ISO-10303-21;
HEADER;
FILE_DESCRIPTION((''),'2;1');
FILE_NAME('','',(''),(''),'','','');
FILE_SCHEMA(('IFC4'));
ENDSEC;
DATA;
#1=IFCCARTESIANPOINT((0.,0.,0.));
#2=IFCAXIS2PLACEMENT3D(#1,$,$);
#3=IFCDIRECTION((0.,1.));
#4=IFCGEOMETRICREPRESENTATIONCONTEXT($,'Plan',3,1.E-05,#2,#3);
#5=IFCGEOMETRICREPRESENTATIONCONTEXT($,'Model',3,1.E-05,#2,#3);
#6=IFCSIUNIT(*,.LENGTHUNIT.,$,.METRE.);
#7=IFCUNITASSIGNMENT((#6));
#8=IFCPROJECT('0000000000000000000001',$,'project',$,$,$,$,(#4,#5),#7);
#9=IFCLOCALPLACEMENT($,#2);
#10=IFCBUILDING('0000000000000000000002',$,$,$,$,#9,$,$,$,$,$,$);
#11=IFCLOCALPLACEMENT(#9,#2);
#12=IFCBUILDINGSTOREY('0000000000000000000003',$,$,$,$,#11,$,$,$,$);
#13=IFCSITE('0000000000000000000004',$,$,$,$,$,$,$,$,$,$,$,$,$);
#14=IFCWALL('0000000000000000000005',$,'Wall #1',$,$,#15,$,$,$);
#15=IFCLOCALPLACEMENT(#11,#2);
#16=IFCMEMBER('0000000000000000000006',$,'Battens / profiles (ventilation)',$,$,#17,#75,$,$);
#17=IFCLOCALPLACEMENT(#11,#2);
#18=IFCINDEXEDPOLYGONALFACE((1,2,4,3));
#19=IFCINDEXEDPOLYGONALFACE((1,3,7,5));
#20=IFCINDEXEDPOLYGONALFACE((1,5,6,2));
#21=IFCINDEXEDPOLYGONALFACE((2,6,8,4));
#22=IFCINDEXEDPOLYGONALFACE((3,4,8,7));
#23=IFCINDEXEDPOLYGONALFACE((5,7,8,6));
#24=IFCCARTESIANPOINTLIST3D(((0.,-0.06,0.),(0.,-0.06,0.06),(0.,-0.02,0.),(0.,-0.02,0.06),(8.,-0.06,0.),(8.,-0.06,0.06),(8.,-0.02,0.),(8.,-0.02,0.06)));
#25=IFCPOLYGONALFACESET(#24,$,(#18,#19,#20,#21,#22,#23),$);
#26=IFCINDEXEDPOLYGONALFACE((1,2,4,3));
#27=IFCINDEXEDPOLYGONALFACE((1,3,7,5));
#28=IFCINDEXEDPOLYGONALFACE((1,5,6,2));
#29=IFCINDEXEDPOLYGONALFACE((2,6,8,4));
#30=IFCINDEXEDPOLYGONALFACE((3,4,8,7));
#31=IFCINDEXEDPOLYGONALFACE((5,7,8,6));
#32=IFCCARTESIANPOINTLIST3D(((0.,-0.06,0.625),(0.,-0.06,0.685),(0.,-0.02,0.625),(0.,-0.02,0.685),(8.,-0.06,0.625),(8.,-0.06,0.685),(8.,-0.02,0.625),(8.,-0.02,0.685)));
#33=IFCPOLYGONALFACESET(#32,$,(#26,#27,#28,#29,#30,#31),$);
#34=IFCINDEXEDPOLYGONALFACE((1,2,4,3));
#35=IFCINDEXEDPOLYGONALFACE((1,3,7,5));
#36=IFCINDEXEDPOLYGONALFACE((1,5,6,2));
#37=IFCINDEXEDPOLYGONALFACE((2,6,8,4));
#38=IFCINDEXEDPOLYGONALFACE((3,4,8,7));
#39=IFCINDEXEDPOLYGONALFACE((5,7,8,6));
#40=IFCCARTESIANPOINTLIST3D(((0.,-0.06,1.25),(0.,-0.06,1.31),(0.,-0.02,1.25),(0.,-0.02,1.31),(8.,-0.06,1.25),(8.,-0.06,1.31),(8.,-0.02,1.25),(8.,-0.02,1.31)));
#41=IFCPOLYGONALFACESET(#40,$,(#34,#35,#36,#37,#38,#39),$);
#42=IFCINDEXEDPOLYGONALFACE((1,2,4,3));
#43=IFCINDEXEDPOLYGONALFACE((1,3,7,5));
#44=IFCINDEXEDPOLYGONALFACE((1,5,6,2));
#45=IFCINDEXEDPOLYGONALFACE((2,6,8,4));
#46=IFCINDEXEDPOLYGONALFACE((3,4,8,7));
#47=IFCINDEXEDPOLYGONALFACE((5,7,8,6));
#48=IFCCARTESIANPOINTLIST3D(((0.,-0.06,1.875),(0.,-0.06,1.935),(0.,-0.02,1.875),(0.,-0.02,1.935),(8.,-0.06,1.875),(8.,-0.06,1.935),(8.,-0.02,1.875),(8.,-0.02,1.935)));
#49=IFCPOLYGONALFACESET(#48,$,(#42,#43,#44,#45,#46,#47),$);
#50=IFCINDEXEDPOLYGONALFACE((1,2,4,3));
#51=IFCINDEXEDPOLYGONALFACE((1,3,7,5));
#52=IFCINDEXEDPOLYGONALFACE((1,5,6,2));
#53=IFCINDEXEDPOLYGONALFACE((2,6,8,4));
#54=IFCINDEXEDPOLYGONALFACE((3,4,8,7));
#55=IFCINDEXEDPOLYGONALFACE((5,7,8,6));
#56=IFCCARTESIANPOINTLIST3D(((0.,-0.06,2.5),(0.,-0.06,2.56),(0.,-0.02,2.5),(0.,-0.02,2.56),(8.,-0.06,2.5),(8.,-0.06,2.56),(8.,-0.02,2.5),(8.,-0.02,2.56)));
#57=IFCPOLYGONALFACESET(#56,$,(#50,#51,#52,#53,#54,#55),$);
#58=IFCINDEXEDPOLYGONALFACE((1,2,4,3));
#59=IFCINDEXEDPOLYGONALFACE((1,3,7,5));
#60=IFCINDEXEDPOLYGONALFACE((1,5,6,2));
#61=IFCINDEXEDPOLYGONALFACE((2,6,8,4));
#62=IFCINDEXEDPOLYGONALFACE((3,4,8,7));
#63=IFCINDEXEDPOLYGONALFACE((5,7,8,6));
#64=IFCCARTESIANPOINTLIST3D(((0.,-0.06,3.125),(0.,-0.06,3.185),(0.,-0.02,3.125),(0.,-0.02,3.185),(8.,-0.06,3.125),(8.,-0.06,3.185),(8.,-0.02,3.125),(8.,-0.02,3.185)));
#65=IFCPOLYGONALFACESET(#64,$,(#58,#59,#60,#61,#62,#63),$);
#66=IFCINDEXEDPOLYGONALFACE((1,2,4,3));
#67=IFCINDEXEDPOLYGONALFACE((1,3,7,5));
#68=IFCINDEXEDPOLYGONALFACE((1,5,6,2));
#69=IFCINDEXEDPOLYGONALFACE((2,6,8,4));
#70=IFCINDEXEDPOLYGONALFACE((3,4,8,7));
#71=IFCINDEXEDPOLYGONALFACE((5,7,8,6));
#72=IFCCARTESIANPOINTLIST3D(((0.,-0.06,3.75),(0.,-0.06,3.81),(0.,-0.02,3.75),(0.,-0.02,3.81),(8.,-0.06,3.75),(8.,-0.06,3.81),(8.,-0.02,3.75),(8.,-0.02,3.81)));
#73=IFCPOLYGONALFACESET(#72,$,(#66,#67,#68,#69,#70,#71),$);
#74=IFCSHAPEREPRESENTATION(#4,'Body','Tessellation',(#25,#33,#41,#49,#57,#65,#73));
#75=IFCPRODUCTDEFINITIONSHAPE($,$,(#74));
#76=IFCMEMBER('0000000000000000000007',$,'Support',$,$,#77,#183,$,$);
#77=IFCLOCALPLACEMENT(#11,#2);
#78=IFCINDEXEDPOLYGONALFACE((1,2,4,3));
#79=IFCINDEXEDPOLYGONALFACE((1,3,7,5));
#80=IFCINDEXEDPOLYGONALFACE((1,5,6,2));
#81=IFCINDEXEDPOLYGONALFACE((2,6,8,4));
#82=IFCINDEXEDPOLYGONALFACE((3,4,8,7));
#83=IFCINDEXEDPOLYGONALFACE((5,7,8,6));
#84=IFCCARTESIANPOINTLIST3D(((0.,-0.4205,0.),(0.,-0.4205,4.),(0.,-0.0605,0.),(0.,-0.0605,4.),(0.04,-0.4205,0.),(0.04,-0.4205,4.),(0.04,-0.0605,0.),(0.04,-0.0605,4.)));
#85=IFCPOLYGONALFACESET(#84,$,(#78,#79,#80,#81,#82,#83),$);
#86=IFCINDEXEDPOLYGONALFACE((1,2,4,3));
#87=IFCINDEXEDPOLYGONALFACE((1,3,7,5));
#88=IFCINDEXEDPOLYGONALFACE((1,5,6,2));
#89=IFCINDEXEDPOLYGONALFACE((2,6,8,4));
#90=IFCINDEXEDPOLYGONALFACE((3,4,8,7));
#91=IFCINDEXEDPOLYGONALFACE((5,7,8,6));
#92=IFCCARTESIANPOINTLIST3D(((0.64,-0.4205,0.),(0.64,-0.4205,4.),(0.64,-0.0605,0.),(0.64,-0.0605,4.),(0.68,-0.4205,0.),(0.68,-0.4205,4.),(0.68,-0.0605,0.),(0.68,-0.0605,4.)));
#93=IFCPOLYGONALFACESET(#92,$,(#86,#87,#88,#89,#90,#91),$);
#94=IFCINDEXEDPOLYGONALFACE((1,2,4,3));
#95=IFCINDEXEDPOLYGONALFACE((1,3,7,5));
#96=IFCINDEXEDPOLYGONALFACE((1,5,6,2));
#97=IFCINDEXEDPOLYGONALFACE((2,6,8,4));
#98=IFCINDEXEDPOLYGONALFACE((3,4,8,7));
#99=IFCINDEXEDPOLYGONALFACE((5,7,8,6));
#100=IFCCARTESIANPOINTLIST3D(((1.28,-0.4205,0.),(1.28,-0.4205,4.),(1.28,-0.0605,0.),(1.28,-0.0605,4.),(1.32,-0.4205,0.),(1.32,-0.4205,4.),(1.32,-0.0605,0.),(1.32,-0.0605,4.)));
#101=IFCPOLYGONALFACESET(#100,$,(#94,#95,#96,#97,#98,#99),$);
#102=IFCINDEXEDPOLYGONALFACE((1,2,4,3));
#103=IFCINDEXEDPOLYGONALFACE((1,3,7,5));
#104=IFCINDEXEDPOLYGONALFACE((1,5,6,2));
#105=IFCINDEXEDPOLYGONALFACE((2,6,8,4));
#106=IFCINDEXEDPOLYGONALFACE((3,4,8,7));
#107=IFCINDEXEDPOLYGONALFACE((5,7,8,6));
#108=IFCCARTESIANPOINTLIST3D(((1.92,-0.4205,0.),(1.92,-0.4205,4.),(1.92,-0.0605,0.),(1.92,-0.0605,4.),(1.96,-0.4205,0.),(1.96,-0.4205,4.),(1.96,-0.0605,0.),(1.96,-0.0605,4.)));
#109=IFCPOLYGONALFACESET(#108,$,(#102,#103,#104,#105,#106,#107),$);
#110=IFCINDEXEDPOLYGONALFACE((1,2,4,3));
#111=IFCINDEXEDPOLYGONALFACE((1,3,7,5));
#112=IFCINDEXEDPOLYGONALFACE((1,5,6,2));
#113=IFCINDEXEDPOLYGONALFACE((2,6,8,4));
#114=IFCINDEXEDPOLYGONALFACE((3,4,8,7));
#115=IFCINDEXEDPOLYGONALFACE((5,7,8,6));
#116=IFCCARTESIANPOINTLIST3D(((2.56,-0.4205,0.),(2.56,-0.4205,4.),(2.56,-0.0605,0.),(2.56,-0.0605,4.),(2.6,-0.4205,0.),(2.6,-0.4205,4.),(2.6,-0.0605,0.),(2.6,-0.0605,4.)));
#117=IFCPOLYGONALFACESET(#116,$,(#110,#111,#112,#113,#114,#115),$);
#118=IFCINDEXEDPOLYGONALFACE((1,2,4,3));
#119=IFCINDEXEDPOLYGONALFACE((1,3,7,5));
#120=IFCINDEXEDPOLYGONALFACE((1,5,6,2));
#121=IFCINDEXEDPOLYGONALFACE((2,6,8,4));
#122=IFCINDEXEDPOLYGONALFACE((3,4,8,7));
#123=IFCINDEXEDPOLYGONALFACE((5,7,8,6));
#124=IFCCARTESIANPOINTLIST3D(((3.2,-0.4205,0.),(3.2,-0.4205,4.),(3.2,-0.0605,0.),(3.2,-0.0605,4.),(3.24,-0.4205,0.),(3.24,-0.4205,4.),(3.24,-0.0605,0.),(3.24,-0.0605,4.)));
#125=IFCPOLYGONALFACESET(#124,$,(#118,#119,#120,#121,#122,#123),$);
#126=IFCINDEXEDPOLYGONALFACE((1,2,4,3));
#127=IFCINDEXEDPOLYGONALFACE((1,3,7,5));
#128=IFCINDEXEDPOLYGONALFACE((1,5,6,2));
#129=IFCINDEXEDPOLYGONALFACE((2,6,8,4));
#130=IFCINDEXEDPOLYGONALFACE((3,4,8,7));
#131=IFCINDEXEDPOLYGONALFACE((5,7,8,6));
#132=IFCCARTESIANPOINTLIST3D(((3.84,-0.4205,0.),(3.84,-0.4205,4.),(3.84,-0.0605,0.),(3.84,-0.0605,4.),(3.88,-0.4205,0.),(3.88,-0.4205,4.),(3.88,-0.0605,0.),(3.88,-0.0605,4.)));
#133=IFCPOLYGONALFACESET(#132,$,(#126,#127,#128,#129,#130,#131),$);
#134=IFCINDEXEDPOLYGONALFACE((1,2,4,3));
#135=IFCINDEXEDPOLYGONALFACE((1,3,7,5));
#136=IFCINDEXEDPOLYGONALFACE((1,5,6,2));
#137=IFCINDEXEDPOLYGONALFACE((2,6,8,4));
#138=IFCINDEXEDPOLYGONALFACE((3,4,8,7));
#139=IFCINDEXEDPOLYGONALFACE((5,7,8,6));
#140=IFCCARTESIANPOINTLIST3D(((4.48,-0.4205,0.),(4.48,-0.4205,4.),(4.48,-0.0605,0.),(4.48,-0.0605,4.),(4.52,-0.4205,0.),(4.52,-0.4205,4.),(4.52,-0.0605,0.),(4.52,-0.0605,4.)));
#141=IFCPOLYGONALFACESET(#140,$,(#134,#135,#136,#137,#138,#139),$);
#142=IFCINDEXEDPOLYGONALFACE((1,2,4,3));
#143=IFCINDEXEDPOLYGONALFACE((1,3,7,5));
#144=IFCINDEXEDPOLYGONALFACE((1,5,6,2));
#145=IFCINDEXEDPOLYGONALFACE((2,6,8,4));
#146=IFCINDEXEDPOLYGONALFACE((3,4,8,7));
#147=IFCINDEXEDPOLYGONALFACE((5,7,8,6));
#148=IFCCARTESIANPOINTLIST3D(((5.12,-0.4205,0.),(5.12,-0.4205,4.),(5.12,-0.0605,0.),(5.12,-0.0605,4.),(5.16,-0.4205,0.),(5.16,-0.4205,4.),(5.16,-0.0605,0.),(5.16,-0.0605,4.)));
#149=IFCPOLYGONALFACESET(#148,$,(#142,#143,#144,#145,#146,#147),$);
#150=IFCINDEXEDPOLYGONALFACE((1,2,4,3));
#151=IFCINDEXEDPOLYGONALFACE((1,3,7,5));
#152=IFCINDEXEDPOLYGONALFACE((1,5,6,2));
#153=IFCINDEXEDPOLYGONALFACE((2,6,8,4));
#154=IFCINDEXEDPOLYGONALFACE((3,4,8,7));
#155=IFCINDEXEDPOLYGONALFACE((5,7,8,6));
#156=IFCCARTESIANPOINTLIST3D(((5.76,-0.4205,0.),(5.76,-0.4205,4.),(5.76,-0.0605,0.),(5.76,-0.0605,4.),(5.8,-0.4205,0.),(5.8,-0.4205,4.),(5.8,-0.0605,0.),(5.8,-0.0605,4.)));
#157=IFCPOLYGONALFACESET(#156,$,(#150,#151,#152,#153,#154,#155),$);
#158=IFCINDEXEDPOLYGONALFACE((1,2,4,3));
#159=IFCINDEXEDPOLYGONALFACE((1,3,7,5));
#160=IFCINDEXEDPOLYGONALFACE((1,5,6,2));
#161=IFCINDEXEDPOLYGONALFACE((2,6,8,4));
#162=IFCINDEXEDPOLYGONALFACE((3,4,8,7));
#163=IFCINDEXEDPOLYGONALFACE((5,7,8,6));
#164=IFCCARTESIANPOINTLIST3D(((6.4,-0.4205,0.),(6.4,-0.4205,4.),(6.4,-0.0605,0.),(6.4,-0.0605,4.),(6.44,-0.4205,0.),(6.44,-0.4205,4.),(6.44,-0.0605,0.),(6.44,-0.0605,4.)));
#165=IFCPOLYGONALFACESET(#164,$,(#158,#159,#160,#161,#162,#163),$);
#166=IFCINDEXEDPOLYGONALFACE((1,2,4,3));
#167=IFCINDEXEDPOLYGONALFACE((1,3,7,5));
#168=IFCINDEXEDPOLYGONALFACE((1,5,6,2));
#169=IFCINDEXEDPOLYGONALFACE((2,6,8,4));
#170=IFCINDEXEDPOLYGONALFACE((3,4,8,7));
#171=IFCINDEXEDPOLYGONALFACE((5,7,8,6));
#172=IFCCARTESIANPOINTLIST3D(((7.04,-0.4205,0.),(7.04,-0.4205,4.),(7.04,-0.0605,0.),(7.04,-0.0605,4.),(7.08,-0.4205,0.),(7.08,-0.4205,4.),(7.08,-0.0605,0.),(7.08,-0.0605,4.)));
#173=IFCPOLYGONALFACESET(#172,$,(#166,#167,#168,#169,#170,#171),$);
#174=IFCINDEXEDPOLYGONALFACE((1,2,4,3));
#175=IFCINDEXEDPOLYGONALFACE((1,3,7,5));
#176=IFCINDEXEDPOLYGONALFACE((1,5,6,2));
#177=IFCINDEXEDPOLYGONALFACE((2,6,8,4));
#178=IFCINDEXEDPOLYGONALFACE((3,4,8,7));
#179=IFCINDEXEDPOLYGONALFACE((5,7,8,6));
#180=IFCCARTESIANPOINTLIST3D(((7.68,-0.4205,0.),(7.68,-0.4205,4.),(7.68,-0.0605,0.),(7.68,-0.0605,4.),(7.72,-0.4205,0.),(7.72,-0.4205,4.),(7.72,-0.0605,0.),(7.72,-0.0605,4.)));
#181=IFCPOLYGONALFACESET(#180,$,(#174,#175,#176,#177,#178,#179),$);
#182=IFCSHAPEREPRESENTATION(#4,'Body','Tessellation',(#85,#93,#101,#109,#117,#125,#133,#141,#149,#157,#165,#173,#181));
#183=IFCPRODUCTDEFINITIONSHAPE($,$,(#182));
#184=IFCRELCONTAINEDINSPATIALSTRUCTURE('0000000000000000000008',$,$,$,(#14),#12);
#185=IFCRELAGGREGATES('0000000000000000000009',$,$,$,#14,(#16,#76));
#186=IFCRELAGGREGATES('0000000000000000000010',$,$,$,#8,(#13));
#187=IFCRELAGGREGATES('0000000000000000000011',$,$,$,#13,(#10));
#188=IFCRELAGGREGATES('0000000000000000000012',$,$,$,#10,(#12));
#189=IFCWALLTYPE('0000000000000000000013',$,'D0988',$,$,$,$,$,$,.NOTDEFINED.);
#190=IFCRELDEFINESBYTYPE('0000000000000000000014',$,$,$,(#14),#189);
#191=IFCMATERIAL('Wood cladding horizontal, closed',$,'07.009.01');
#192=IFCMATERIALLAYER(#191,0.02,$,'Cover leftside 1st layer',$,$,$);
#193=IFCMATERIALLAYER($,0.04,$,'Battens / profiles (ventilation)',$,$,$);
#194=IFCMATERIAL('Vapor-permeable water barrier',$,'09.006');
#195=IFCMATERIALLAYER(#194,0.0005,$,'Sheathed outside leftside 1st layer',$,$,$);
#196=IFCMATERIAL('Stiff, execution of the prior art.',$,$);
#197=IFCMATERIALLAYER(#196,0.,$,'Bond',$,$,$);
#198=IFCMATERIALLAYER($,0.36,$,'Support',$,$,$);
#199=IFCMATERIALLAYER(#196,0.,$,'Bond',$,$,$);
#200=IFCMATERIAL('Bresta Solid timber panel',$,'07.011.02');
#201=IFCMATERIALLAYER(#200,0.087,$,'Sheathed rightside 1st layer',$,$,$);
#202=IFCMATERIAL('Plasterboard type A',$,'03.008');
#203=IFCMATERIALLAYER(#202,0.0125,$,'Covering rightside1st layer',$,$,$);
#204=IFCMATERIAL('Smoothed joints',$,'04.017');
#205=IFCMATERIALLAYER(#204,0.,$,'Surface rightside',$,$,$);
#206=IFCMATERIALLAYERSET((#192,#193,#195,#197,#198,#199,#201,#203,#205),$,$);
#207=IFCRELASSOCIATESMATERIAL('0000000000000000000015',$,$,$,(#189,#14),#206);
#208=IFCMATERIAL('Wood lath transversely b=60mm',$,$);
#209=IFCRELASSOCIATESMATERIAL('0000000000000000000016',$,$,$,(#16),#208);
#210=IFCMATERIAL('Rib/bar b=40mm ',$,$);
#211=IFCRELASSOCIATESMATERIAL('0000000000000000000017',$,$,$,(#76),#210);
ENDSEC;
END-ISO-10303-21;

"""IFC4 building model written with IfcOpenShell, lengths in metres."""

from ifc_helpers import new_model, si_unit, direction, frame, frame_2d, origin, place, context, project, spatial, rectangle, extrude, material, layer, layer_set, type_object, element, aggregate, save


model = new_model("IFC4")

# Units and contexts
plan_context = context("Plan", 3, precision=1e-05, world=origin(), true_north=direction((0.0, 1.0)))
model_context = context("Model", 3, precision=1e-05, world=origin(), true_north=direction((0.0, 1.0)))
ifc_project = project(units=[si_unit("LENGTHUNIT", "METRE")], contexts=[plan_context, model_context])

# Site, building, storey
site = spatial("IfcSite", under=ifc_project)
building_placement = place(None, origin())
building = spatial("IfcBuilding", under=site, at=building_placement)
storey_placement = place(building_placement, origin())
storey = spatial("IfcBuildingStorey", under=building, at=storey_placement)

# Wall, members
ifc_material_1 = material(Name="Wood cladding horizontal, closed", Category="07.009.01")
ifc_layer_1 = layer(ifc_material_1, 0.02, Name="Cover leftside 1st layer")
ifc_layer_2 = layer(None, 0.04, Name="Battens / profiles (ventilation)")
ifc_material_2 = material(Name="Vapor-permeable water barrier", Category="09.006")
ifc_layer_3 = layer(ifc_material_2, 0.0005, Name="Sheathed outside leftside 1st layer")
ifc_material_3 = material(Name="Stiff, execution of the prior art.")
ifc_layer_4 = layer(ifc_material_3, 0.0, Name="Bond")
ifc_layer_5 = layer(None, 0.36, Name="Support")
ifc_layer_6 = layer(ifc_material_3, 0.0, Name="Bond")
ifc_material_4 = material(Name="Bresta Solid timber panel", Category="07.011.02")
ifc_layer_7 = layer(ifc_material_4, 0.087, Name="Sheathed rightside 1st layer")
ifc_material_5 = material(Name="Plasterboard type A", Category="03.008")
ifc_layer_8 = layer(ifc_material_5, 0.0125, Name="Covering rightside1st layer")
ifc_material_6 = material(Name="Smoothed joints", Category="04.017")
ifc_layer_9 = layer(ifc_material_6, 0.0, Name="Surface rightside")
ifc_layer_set = layer_set([ifc_layer_1, ifc_layer_2, ifc_layer_3, ifc_layer_4, ifc_layer_5, ifc_layer_6, ifc_layer_7, ifc_layer_8, ifc_layer_9])
wall_type = type_object("IfcWallType", Name="D0988", PredefinedType="NOTDEFINED", material=ifc_layer_set)
wall_placement = place(None, frame((0.0, 0.0, 0.0), z_axis=(0.0, -1.0, 0.0), x_axis=(1.0, 0.0, 0.0)))
wall = element("IfcWall", 1, at=wall_placement, inside=storey, type_object=wall_type, material=ifc_layer_set, Name="Wall #1")
ifc_material_7 = material(Name="Wood lath transversely b=60mm")
member_1_placement = place(wall_placement, origin())
member_1 = element("IfcMember", 2, at=member_1_placement, material=ifc_material_7, Name="Battens / profiles (ventilation)", context=plan_context, shape_type="SweptSolid", body=[
    extrude(rectangle(XDim=0.06, YDim=0.04, at=frame_2d((0.03, 0.02), x_axis=(1.0, 0.0))), frame((0.0, 0.0, 0.02), z_axis=(1.0, 0.0, 0.0), x_axis=(0.0, 1.0, 0.0)), (0.0, 0.0, 1.0), 8.0),
    extrude(rectangle(XDim=0.06, YDim=0.04, at=frame_2d((0.03, 0.02), x_axis=(1.0, 0.0))), frame((0.0, 0.625, 0.02), z_axis=(1.0, 0.0, 0.0), x_axis=(0.0, 1.0, 0.0)), (0.0, 0.0, 1.0), 8.0),
    extrude(rectangle(XDim=0.06, YDim=0.04, at=frame_2d((0.03, 0.02), x_axis=(1.0, 0.0))), frame((0.0, 1.25, 0.02), z_axis=(1.0, 0.0, 0.0), x_axis=(0.0, 1.0, 0.0)), (0.0, 0.0, 1.0), 8.0),
    extrude(rectangle(XDim=0.06, YDim=0.04, at=frame_2d((0.03, 0.02), x_axis=(1.0, 0.0))), frame((0.0, 1.875, 0.02), z_axis=(1.0, 0.0, 0.0), x_axis=(0.0, 1.0, 0.0)), (0.0, 0.0, 1.0), 8.0),
    extrude(rectangle(XDim=0.06, YDim=0.04, at=frame_2d((0.03, 0.02), x_axis=(1.0, 0.0))), frame((0.0, 2.5, 0.02), z_axis=(1.0, 0.0, 0.0), x_axis=(0.0, 1.0, 0.0)), (0.0, 0.0, 1.0), 8.0),
    extrude(rectangle(XDim=0.06, YDim=0.04, at=frame_2d((0.03, 0.02), x_axis=(1.0, 0.0))), frame((0.0, 3.125, 0.02), z_axis=(1.0, 0.0, 0.0), x_axis=(0.0, 1.0, 0.0)), (0.0, 0.0, 1.0), 8.0),
    extrude(rectangle(XDim=0.06, YDim=0.04, at=frame_2d((0.03, 0.02), x_axis=(1.0, 0.0))), frame((0.0, 3.75, 0.02), z_axis=(1.0, 0.0, 0.0), x_axis=(0.0, 1.0, 0.0)), (0.0, 0.0, 1.0), 8.0),
])
ifc_material_8 = material(Name="Rib/bar b=40mm ")
member_2_placement = place(wall_placement, origin())
member_2 = element("IfcMember", 3, at=member_2_placement, material=ifc_material_8, Name="Support", context=plan_context, shape_type="SweptSolid", body=[
    extrude(rectangle(XDim=0.04, YDim=0.36, at=frame_2d((0.02, 0.18), x_axis=(1.0, 0.0))), frame((0.0, 4.0, 0.0605), z_axis=(0.0, -1.0, 0.0), x_axis=(1.0, 0.0, 0.0)), (0.0, 0.0, 1.0), 4.0),
    extrude(rectangle(XDim=0.04, YDim=0.36, at=frame_2d((0.02, 0.18), x_axis=(1.0, 0.0))), frame((0.64, 4.0, 0.0605), z_axis=(0.0, -1.0, 0.0), x_axis=(1.0, 0.0, 0.0)), (0.0, 0.0, 1.0), 4.0),
    extrude(rectangle(XDim=0.04, YDim=0.36, at=frame_2d((0.02, 0.18), x_axis=(1.0, 0.0))), frame((1.28, 4.0, 0.0605), z_axis=(0.0, -1.0, 0.0), x_axis=(1.0, 0.0, 0.0)), (0.0, 0.0, 1.0), 4.0),
    extrude(rectangle(XDim=0.04, YDim=0.36, at=frame_2d((0.02, 0.18), x_axis=(1.0, 0.0))), frame((1.92, 4.0, 0.0605), z_axis=(0.0, -1.0, 0.0), x_axis=(1.0, 0.0, 0.0)), (0.0, 0.0, 1.0), 4.0),
    extrude(rectangle(XDim=0.04, YDim=0.36, at=frame_2d((0.02, 0.18), x_axis=(1.0, 0.0))), frame((2.56, 4.0, 0.0605), z_axis=(0.0, -1.0, 0.0), x_axis=(1.0, 0.0, 0.0)), (0.0, 0.0, 1.0), 4.0),
    extrude(rectangle(XDim=0.04, YDim=0.36, at=frame_2d((0.02, 0.18), x_axis=(1.0, 0.0))), frame((3.2, 4.0, 0.0605), z_axis=(0.0, -1.0, 0.0), x_axis=(1.0, 0.0, 0.0)), (0.0, 0.0, 1.0), 4.0),
    extrude(rectangle(XDim=0.04, YDim=0.36, at=frame_2d((0.02, 0.18), x_axis=(1.0, 0.0))), frame((3.84, 4.0, 0.0605), z_axis=(0.0, -1.0, 0.0), x_axis=(1.0, 0.0, 0.0)), (0.0, 0.0, 1.0), 4.0),
    extrude(rectangle(XDim=0.04, YDim=0.36, at=frame_2d((0.02, 0.18), x_axis=(1.0, 0.0))), frame((4.48, 4.0, 0.0605), z_axis=(0.0, -1.0, 0.0), x_axis=(1.0, 0.0, 0.0)), (0.0, 0.0, 1.0), 4.0),
    extrude(rectangle(XDim=0.04, YDim=0.36, at=frame_2d((0.02, 0.18), x_axis=(1.0, 0.0))), frame((5.12, 4.0, 0.0605), z_axis=(0.0, -1.0, 0.0), x_axis=(1.0, 0.0, 0.0)), (0.0, 0.0, 1.0), 4.0),
    extrude(rectangle(XDim=0.04, YDim=0.36, at=frame_2d((0.02, 0.18), x_axis=(1.0, 0.0))), frame((5.76, 4.0, 0.0605), z_axis=(0.0, -1.0, 0.0), x_axis=(1.0, 0.0, 0.0)), (0.0, 0.0, 1.0), 4.0),
    extrude(rectangle(XDim=0.04, YDim=0.36, at=frame_2d((0.02, 0.18), x_axis=(1.0, 0.0))), frame((6.4, 4.0, 0.0605), z_axis=(0.0, -1.0, 0.0), x_axis=(1.0, 0.0, 0.0)), (0.0, 0.0, 1.0), 4.0),
    extrude(rectangle(XDim=0.04, YDim=0.36, at=frame_2d((0.02, 0.18), x_axis=(1.0, 0.0))), frame((7.04, 4.0, 0.0605), z_axis=(0.0, -1.0, 0.0), x_axis=(1.0, 0.0, 0.0)), (0.0, 0.0, 1.0), 4.0),
    extrude(rectangle(XDim=0.04, YDim=0.36, at=frame_2d((0.02, 0.18), x_axis=(1.0, 0.0))), frame((7.68, 4.0, 0.0605), z_axis=(0.0, -1.0, 0.0), x_axis=(1.0, 0.0, 0.0)), (0.0, 0.0, 1.0), 4.0),
])
aggregate(wall, [member_1, member_2])

save(model, "model.ifc")
